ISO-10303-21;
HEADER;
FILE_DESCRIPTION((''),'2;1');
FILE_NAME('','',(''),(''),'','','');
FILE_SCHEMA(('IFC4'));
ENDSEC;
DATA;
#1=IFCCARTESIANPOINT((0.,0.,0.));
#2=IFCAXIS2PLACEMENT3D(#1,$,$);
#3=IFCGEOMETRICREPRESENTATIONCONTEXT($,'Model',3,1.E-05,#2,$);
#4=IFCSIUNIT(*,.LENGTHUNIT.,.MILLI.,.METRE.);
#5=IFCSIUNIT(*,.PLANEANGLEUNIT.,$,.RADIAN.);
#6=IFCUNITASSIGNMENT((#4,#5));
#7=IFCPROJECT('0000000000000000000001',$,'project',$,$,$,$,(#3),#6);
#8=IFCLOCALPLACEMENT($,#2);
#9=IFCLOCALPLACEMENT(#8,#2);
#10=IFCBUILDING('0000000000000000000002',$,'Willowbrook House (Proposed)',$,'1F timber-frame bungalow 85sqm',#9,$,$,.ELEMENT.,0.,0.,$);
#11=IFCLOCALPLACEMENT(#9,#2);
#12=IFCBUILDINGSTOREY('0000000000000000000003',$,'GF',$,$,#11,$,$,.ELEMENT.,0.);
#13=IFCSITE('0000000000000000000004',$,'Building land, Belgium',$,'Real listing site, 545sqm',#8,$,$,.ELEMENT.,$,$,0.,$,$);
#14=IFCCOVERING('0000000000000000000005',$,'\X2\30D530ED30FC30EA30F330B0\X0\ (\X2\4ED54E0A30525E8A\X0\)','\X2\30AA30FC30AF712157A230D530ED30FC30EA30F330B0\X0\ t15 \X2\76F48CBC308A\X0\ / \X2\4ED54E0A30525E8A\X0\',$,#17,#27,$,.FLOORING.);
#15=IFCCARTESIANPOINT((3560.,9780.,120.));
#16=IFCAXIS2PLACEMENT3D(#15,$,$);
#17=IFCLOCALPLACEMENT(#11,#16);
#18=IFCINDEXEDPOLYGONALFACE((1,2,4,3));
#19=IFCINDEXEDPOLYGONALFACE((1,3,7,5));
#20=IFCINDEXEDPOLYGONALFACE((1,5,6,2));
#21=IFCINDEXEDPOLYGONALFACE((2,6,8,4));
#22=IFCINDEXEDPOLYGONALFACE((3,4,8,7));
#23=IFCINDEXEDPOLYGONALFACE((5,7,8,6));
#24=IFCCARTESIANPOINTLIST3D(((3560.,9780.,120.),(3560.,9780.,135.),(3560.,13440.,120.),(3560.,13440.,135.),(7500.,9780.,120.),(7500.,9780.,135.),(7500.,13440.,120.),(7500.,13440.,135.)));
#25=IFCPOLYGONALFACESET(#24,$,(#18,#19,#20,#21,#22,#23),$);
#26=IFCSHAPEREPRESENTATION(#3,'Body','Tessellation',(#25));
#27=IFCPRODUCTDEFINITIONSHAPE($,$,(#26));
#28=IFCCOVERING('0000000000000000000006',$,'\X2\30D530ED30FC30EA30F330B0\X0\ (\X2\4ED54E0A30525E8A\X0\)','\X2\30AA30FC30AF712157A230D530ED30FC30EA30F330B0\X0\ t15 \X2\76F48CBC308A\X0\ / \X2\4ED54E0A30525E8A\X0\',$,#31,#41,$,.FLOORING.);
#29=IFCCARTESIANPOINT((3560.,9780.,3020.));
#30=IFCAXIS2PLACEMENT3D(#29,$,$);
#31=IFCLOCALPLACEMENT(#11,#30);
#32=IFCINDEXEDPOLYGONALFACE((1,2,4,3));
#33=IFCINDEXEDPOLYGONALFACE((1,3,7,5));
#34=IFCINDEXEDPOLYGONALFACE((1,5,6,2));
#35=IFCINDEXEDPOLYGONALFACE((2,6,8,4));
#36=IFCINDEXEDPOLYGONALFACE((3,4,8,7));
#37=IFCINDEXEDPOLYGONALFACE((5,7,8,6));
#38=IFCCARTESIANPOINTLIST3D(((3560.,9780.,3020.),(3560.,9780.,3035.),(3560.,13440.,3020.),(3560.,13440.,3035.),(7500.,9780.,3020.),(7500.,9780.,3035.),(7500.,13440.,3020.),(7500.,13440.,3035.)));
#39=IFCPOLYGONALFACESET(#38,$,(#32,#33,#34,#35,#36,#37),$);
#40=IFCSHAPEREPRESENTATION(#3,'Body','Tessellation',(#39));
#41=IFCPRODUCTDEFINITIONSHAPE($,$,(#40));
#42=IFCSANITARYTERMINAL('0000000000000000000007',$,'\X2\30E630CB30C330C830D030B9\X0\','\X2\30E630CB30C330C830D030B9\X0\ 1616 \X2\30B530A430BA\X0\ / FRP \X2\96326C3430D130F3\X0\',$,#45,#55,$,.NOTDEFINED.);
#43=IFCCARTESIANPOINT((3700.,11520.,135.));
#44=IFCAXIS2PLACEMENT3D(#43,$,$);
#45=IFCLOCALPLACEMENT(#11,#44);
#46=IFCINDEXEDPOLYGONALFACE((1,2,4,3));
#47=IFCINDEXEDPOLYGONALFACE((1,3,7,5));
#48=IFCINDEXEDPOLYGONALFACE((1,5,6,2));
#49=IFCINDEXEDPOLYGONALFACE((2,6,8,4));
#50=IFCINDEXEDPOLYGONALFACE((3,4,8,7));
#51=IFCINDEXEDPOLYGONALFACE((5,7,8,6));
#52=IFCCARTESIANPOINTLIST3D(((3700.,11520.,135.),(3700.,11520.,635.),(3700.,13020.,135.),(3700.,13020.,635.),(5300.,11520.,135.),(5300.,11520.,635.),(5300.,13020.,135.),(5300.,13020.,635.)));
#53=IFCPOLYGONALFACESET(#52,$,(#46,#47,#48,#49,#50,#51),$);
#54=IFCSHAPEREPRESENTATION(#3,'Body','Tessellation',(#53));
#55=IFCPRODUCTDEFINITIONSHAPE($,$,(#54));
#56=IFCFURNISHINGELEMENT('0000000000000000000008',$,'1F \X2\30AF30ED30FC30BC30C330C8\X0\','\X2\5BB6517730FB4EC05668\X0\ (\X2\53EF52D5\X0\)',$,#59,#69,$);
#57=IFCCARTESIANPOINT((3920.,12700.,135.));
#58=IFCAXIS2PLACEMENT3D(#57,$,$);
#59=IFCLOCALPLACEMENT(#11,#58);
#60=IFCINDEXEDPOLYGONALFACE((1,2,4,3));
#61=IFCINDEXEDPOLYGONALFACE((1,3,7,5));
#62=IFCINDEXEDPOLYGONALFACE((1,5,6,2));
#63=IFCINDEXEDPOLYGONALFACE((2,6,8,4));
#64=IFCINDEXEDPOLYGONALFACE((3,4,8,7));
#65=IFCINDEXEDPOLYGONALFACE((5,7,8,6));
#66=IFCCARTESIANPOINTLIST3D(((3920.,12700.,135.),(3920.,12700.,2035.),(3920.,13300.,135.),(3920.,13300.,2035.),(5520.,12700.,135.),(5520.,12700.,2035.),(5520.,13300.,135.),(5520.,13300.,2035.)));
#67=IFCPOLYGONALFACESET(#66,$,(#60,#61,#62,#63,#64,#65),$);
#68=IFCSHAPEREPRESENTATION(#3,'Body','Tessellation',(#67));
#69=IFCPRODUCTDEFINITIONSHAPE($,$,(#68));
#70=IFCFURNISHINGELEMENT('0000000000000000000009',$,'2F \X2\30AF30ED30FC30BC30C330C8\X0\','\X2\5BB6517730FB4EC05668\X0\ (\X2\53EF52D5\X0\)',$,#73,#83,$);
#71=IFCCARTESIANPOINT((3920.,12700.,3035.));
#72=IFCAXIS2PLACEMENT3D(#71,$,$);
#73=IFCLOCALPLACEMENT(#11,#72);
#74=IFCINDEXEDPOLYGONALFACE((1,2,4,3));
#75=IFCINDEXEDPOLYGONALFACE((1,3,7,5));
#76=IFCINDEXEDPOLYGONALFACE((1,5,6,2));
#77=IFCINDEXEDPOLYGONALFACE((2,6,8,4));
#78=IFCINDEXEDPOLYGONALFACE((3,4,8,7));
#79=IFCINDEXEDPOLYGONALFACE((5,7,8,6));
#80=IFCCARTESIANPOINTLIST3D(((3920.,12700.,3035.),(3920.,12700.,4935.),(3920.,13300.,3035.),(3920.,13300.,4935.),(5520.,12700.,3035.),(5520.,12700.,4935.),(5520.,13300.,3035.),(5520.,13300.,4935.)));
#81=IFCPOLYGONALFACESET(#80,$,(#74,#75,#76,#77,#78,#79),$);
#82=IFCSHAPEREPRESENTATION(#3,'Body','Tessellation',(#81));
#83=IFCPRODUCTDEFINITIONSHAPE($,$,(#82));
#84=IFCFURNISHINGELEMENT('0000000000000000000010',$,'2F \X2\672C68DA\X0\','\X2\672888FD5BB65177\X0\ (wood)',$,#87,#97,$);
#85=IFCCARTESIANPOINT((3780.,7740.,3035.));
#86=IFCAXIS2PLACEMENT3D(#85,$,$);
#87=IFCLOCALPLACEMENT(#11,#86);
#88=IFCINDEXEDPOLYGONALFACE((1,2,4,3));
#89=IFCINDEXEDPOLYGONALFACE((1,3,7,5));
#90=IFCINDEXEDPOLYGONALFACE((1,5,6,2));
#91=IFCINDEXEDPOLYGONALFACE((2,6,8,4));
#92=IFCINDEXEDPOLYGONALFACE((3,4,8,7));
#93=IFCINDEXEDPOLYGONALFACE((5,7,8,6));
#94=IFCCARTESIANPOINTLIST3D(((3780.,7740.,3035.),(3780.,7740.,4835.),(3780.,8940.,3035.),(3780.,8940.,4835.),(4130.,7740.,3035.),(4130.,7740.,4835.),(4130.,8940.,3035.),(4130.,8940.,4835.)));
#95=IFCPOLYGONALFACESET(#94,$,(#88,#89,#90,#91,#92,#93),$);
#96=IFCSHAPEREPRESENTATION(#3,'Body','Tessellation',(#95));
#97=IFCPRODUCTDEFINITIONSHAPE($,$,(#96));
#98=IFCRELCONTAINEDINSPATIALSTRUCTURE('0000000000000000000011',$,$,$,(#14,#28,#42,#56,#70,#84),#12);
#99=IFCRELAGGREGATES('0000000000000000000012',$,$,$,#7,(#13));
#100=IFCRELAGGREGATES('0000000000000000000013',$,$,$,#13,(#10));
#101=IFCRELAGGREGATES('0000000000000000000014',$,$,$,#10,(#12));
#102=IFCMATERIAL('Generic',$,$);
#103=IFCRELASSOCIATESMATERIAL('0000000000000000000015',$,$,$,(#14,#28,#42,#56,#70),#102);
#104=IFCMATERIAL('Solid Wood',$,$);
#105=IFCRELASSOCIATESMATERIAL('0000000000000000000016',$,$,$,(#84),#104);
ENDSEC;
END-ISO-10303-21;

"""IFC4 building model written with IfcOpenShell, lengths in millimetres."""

from ifc_helpers import new_model, si_unit, frame, frame_2d, origin, place, context, project, spatial, rectangle, extrude, material, element, save


model = new_model("IFC4")

# Units and contexts
model_context = context("Model", 3, precision=1e-05, world=origin())
ifc_project = project(units=[si_unit("LENGTHUNIT", "METRE", prefix="MILLI"), si_unit("PLANEANGLEUNIT", "RADIAN")], contexts=[model_context])

# Site, building, storey
site_placement = place(None, origin())
site = spatial("IfcSite", under=ifc_project, at=site_placement, Name="Building land, Belgium", ObjectType="Real listing site, 545sqm", CompositionType="ELEMENT", RefElevation=0.0)
building_placement = place(site_placement, origin())
building = spatial("IfcBuilding", under=site, at=building_placement, Name="Willowbrook House (Proposed)", ObjectType="1F timber-frame bungalow 85sqm", CompositionType="ELEMENT", ElevationOfRefHeight=0.0, ElevationOfTerrain=0.0)
storey_placement = place(building_placement, origin())
storey = spatial("IfcBuildingStorey", under=building, at=storey_placement, Name="GF", CompositionType="ELEMENT", Elevation=0.0)

# Shared definitions
ifc_material_1 = material(Name="Solid Wood")

# Coverings
ifc_material_2 = material(Name="Generic")
covering_1_placement = place(storey_placement, frame((3560.0, 9780.0, 120.0)))
element("IfcCovering", 1, at=covering_1_placement, inside=storey, material=ifc_material_2, Name="フローリング (仕上げ床)", Description="オーク無垢フローリング t15 直貼り / 仕上げ床", PredefinedType="FLOORING", context=model_context, shape_type="SweptSolid", body=[
    extrude(rectangle(XDim=3940.0, YDim=3660.0, at=frame_2d((1970.0, 1830.0))), frame((3560.0, 9780.0, 120.0)), (0.0, 0.0, 1.0), 15.0),
])
covering_2_placement = place(storey_placement, frame((3560.0, 9780.0, 3020.0)))
element("IfcCovering", 2, at=covering_2_placement, inside=storey, material=ifc_material_2, Name="フローリング (仕上げ床)", Description="オーク無垢フローリング t15 直貼り / 仕上げ床", PredefinedType="FLOORING", context=model_context, shape_type="SweptSolid", body=[
    extrude(rectangle(XDim=3940.0, YDim=3660.0, at=frame_2d((1970.0, 1830.0))), frame((3560.0, 9780.0, 3020.0)), (0.0, 0.0, 1.0), 15.0),
])

# Sanitary terminal
sanitary_terminal_placement = place(storey_placement, frame((3700.0, 11520.0, 135.0)))
element("IfcSanitaryTerminal", 3, at=sanitary_terminal_placement, inside=storey, material=ifc_material_2, Name="ユニットバス", Description="ユニットバス 1616 サイズ / FRP 防水パン", PredefinedType="NOTDEFINED", context=model_context, shape_type="SweptSolid", body=[
    extrude(rectangle(XDim=1600.0, YDim=1500.0, at=frame_2d((800.0, 750.0))), frame((3700.0, 11520.0, 135.0)), (0.0, 0.0, 1.0), 500.0),
])

# Furnishing elements
furnishing_1_placement = place(storey_placement, frame((3920.0, 12700.0, 135.0)))
element("IfcFurnishingElement", 4, at=furnishing_1_placement, inside=storey, material=ifc_material_2, Name="1F クローゼット", Description="家具・什器 (可動)", context=model_context, shape_type="SweptSolid", body=[
    extrude(rectangle(XDim=1600.0, YDim=600.0, at=frame_2d((800.0, 300.0))), frame((3920.0, 12700.0, 135.0)), (0.0, 0.0, 1.0), 1900.0),
])
furnishing_2_placement = place(storey_placement, frame((3920.0, 12700.0, 3035.0)))
element("IfcFurnishingElement", 5, at=furnishing_2_placement, inside=storey, material=ifc_material_2, Name="2F クローゼット", Description="家具・什器 (可動)", context=model_context, shape_type="SweptSolid", body=[
    extrude(rectangle(XDim=1600.0, YDim=600.0, at=frame_2d((800.0, 300.0))), frame((3920.0, 12700.0, 3035.0)), (0.0, 0.0, 1.0), 1900.0),
])
furnishing_3_placement = place(storey_placement, frame((3780.0, 7740.0, 3035.0)))
element("IfcFurnishingElement", 6, at=furnishing_3_placement, inside=storey, material=ifc_material_1, Name="2F 本棚", Description="木製家具 (wood)", context=model_context, shape_type="SweptSolid", body=[
    extrude(rectangle(XDim=350.0, YDim=1200.0, at=frame_2d((175.0, 600.0))), frame((3780.0, 7740.0, 3035.0)), (0.0, 0.0, 1.0), 1800.0),
])

save(model, "model.ifc")
